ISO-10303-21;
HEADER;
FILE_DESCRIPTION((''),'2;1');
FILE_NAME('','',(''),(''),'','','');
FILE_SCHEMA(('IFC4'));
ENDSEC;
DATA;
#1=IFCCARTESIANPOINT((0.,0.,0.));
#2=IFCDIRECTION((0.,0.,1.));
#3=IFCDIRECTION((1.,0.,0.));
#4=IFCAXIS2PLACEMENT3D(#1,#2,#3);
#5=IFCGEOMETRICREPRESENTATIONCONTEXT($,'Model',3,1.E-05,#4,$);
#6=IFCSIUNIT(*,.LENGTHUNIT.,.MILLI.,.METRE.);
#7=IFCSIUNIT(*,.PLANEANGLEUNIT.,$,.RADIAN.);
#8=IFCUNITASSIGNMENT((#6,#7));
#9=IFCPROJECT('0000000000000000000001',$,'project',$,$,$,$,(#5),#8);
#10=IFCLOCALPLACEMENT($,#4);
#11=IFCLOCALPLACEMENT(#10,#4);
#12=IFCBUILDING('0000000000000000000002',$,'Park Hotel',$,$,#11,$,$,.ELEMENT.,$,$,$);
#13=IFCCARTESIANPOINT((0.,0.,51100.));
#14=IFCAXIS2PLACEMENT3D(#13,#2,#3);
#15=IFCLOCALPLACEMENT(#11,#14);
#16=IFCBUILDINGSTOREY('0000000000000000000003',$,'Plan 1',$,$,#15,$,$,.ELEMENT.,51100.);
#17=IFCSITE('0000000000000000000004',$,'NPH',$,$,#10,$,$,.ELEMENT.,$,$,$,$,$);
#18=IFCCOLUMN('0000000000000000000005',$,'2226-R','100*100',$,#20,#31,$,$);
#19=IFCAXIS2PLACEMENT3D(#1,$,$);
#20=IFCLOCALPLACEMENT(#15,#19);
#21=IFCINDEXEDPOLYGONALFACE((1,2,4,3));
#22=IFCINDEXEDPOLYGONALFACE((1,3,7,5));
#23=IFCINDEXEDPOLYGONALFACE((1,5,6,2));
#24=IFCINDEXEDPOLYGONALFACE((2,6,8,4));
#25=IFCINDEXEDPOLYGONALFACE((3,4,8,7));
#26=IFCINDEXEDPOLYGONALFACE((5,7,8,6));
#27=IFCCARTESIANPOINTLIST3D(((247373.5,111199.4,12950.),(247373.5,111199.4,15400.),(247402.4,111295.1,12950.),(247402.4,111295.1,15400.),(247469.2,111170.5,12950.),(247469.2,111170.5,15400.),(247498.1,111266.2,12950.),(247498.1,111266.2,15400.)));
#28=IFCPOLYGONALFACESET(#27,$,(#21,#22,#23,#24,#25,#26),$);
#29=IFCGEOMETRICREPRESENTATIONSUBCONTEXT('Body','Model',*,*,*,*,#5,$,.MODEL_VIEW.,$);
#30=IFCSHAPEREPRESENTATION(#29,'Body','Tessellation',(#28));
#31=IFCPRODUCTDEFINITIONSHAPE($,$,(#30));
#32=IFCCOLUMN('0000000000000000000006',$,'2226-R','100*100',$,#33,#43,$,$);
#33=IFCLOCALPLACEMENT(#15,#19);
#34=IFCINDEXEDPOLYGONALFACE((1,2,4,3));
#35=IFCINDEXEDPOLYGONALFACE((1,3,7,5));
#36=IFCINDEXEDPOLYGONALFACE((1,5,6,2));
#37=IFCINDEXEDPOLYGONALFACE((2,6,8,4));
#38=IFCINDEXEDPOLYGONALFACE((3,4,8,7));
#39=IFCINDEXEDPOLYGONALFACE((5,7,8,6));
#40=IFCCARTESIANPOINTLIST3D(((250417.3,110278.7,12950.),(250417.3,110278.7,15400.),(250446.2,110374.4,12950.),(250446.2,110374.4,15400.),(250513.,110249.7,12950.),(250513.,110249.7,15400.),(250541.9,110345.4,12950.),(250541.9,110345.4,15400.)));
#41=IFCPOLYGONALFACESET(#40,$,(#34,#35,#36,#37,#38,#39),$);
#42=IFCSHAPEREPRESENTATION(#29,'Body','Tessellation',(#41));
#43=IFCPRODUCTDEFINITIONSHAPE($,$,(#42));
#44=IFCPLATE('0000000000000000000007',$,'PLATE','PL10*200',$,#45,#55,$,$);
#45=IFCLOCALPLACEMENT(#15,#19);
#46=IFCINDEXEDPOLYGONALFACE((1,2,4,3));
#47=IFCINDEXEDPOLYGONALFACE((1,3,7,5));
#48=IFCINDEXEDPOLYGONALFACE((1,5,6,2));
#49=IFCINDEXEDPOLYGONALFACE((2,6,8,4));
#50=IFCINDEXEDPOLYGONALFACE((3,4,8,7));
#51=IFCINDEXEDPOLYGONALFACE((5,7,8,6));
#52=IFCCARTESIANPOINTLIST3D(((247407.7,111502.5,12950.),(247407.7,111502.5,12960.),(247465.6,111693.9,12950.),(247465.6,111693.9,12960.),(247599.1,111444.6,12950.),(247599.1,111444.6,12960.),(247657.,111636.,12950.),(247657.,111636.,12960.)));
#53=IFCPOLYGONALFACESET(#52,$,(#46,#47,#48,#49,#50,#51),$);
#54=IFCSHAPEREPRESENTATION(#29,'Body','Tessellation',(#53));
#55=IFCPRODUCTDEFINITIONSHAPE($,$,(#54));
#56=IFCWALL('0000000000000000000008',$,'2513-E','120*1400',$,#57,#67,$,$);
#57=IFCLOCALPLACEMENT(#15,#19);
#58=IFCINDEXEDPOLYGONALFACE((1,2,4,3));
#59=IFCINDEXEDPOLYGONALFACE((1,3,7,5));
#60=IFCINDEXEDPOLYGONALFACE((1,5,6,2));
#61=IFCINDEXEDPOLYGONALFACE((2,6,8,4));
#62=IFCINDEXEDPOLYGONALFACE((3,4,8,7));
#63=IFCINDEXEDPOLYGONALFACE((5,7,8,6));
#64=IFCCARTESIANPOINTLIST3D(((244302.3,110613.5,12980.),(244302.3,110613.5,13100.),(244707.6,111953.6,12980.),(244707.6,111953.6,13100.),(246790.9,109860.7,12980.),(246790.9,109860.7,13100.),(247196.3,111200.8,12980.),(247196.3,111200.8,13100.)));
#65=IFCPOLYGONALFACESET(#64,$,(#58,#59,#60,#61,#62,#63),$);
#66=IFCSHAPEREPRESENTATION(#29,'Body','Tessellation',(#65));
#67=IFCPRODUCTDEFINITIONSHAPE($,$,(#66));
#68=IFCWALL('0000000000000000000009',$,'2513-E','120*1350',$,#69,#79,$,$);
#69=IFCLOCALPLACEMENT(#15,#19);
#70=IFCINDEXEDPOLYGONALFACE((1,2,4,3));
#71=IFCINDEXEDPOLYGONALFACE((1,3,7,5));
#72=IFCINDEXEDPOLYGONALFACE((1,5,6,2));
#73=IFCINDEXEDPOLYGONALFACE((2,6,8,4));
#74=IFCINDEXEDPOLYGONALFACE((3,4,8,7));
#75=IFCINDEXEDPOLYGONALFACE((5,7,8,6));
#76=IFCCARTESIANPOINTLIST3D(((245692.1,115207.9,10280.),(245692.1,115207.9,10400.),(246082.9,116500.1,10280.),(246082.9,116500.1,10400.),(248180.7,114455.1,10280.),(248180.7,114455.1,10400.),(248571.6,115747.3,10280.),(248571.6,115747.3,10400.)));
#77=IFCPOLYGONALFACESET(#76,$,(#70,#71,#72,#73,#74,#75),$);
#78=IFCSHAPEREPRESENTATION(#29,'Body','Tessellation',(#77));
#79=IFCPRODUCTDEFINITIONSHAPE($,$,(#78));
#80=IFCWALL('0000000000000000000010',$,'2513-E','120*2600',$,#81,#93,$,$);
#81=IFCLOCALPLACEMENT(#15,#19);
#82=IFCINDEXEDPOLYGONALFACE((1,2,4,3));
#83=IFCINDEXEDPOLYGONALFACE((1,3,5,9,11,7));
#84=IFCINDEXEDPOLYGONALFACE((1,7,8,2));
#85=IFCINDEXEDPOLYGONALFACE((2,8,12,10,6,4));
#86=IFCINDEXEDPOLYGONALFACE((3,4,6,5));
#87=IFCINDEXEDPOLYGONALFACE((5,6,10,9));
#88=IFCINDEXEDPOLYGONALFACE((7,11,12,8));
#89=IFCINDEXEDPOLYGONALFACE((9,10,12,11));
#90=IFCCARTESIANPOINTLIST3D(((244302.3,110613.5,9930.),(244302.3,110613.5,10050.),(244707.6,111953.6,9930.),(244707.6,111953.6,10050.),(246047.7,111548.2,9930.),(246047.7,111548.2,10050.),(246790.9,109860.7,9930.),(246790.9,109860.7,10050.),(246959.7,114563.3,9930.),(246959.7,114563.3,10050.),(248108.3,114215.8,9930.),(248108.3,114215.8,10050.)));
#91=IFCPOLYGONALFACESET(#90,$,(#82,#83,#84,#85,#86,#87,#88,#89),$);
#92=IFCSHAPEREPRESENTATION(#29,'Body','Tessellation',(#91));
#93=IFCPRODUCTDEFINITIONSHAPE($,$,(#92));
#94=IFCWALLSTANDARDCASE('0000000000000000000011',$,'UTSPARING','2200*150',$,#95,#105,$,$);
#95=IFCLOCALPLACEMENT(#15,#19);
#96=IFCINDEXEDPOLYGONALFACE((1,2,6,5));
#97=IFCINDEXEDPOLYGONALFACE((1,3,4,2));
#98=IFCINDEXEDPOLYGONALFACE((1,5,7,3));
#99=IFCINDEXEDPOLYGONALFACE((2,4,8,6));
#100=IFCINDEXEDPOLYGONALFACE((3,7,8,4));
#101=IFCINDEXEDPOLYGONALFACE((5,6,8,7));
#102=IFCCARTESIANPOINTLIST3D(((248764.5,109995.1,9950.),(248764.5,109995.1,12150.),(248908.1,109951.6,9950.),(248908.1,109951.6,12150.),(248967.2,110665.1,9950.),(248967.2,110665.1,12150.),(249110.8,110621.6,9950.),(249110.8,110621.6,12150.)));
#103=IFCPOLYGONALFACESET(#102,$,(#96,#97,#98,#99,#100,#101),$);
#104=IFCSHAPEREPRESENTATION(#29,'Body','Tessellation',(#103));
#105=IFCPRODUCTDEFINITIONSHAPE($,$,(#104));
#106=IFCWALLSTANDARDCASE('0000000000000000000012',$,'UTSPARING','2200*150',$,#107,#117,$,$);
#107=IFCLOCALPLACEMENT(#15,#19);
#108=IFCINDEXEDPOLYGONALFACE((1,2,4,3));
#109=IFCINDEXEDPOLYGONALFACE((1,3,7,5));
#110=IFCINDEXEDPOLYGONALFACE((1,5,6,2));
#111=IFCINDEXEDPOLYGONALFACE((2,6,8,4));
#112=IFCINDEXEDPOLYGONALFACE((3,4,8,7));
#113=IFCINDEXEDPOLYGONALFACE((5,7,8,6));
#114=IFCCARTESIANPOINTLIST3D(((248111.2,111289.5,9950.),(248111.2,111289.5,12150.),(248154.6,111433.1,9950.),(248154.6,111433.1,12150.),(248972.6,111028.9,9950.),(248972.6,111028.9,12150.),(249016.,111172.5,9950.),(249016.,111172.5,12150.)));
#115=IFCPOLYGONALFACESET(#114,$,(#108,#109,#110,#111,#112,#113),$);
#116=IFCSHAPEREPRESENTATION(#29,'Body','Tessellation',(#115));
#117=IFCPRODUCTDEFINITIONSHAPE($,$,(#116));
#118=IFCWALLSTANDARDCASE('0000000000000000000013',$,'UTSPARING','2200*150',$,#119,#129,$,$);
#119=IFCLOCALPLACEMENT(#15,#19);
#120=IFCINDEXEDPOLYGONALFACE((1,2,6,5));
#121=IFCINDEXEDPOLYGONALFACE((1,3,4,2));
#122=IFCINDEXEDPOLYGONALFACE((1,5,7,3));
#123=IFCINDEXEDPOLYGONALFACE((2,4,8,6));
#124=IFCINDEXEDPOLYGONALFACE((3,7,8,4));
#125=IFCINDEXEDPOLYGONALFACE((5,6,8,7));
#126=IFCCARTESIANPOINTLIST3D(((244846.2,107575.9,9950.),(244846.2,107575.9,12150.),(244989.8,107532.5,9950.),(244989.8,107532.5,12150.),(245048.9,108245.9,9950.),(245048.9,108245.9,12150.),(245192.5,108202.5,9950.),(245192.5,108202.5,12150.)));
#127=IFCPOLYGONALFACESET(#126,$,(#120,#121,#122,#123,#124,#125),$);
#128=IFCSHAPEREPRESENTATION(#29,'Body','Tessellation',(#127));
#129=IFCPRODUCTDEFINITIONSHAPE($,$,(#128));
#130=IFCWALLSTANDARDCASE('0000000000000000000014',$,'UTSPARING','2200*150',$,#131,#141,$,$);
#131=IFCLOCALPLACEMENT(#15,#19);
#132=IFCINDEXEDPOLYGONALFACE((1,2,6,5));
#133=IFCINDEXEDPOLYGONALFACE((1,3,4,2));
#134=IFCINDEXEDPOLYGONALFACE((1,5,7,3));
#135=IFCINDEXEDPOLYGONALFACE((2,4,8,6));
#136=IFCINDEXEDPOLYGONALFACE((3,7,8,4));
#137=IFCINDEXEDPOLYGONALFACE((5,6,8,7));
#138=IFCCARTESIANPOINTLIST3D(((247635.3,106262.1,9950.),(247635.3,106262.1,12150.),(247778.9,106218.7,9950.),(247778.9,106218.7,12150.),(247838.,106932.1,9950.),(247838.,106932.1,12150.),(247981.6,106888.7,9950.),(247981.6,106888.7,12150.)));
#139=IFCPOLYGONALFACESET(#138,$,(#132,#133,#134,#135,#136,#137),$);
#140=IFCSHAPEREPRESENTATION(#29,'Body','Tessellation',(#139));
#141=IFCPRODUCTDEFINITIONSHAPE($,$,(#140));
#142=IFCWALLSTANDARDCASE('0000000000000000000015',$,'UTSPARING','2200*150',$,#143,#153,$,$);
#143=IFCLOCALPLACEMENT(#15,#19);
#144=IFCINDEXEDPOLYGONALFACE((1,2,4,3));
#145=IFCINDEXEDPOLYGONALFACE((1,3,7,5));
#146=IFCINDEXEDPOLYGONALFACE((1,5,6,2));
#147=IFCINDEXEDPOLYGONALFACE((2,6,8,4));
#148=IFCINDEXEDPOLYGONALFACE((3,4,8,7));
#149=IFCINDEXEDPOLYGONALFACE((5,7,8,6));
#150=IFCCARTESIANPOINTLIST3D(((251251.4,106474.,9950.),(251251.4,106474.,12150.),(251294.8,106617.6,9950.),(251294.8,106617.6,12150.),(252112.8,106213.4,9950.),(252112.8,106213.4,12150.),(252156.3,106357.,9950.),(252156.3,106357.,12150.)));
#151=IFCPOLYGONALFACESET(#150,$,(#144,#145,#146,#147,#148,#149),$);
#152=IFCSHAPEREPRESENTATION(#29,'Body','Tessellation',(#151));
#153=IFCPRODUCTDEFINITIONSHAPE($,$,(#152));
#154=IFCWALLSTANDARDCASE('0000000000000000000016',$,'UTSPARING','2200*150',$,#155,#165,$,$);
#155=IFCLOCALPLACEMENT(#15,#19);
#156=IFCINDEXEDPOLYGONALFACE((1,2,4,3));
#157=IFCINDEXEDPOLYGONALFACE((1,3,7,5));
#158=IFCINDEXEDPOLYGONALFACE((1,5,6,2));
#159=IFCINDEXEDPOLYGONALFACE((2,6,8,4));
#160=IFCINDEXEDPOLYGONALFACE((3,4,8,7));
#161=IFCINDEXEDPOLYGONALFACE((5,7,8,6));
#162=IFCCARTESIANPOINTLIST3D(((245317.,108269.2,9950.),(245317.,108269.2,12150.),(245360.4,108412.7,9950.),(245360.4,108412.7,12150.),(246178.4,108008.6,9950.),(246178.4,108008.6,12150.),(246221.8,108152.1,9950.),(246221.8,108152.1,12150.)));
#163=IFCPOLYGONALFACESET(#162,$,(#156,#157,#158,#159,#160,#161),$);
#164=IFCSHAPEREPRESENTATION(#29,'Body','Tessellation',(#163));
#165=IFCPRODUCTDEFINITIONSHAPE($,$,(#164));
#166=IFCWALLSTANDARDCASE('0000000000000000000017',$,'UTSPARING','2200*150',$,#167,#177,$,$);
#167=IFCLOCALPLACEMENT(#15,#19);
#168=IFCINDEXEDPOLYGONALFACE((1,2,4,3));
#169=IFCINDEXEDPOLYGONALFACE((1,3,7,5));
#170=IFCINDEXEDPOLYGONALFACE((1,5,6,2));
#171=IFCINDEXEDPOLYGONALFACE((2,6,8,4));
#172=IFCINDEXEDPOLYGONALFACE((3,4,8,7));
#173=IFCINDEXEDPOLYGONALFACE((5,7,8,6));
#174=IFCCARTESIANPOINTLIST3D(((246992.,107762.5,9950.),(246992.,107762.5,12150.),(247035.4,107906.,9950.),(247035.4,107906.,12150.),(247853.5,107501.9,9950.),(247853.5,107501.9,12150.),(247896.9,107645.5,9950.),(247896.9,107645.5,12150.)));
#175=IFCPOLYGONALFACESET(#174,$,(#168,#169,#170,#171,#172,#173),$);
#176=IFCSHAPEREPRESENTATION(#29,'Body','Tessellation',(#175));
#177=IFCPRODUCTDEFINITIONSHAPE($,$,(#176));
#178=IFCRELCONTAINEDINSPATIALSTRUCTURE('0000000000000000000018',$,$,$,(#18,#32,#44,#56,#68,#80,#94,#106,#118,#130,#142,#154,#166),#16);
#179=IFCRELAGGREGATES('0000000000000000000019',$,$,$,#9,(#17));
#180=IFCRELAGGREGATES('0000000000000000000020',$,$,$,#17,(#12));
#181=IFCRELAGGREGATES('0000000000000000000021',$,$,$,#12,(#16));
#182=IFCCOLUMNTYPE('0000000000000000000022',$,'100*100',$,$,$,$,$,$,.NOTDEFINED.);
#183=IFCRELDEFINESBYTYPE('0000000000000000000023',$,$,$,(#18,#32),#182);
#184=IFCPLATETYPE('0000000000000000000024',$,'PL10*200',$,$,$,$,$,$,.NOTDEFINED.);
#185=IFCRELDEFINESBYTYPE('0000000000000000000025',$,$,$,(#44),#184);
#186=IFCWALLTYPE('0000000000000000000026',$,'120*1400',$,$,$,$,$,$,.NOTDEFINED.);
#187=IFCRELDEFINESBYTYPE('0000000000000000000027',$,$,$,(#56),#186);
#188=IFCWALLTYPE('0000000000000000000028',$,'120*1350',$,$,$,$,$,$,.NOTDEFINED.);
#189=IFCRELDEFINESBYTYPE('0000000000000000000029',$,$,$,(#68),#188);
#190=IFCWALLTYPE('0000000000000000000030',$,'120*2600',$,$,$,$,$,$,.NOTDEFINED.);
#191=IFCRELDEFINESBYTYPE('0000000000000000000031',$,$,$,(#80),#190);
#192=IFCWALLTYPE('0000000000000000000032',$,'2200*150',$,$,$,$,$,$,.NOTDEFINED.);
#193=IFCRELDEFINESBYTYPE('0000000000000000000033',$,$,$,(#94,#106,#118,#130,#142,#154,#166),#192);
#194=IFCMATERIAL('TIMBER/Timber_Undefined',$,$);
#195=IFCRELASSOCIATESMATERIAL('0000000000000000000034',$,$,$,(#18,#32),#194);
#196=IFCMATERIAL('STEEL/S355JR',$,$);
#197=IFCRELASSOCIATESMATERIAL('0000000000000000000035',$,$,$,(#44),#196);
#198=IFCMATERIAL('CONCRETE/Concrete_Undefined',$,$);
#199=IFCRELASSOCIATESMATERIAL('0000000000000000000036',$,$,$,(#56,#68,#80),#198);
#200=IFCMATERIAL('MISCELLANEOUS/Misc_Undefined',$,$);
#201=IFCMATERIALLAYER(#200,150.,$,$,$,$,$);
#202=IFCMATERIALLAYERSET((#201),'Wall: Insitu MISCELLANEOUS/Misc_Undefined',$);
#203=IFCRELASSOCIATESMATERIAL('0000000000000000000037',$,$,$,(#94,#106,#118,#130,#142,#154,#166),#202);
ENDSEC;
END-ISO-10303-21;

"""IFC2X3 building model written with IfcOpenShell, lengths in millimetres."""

from ifc_helpers import new_model, si_unit, frame, frame_2d, origin_with_axes, origin_2d_with_axis, place, context, subcontext, project, spatial, polyline, rectangle, outline, extrude, material, layer, layer_set, layer_usage, type_object, element, save


model = new_model("IFC2X3")

# Units and contexts
model_context = context("Model", 3, precision=1e-05, world=origin_with_axes())
body_context = subcontext(model_context, "Body", "Model", "MODEL_VIEW")
ifc_project = project(units=[si_unit("LENGTHUNIT", "METRE", prefix="MILLI"), si_unit("PLANEANGLEUNIT", "RADIAN")], contexts=[model_context])

# Site, building, storey
site_placement = place(None, origin_with_axes())
site = spatial("IfcSite", under=ifc_project, at=site_placement, Name="NPH", CompositionType="ELEMENT")
building_placement = place(site_placement, origin_with_axes())
building = spatial("IfcBuilding", under=site, at=building_placement, Name="Park Hotel", CompositionType="ELEMENT")
storey_placement = place(building_placement, frame((0.0, 0.0, 51100.0), z_axis=(0.0, 0.0, 1.0), x_axis=(1.0, 0.0, 0.0)))
storey = spatial("IfcBuildingStorey", under=building, at=storey_placement, Name="Plan 1", CompositionType="ELEMENT", Elevation=51100.0)

# Columns
ifc_material_1 = material(Name="TIMBER/Timber_Undefined")
column_type = type_object("IfcColumnType", Name="100*100", PredefinedType="NOTDEFINED")
for number, where, z_axis, x_axis, name in (
    (1, (247435.8, 111232.8, 15400.0), (0.0, 0.0, -1.0), (0.289538, 0.957167, 0.0), "2226-R"),
    (2, (250479.6, 110312.1, 15400.0), (0.0, 0.0, -1.0), (0.289538, 0.957167, 0.0), "2226-R"),
):
    element("IfcColumn", number, at=place(storey_placement, frame(where, z_axis=z_axis, x_axis=x_axis)), inside=storey, type_object=column_type, material=ifc_material_1, Name=name, Description="100*100", context=body_context, shape_type="SweptSolid", body=[
        extrude(rectangle(XDim=100.0, YDim=100.0, at=origin_2d_with_axis()), frame((0.0, 0.0, 2450.0), z_axis=(0.0, 0.0, -1.0), x_axis=(0.0, 1.0, 0.0)), (0.0, 0.0, 1.0), 2450.0),
    ])

# Plate
ifc_material_2 = material(Name="STEEL/S355JR")
plate_type = type_object("IfcPlateType", Name="PL10*200", PredefinedType="NOTDEFINED")
plate_placement = place(storey_placement, frame((247628.1, 111540.3, 12955.0), z_axis=(0.0, 0.0, 1.0), x_axis=(-0.957167, 0.289538, 0.0)))
element("IfcPlate", 3, at=plate_placement, inside=storey, type_object=plate_type, material=ifc_material_2, Name="PLATE", Description="PL10*200", context=body_context, shape_type="SweptSolid", body=[
    extrude(outline(polyline([(200.0, 100.0), (200.0, -100.0), (0.0, -100.0), (0.0, 100.0), (200.0, 100.0)])), frame((0.0, 0.0, -5.0), z_axis=(0.0, 0.0, 1.0), x_axis=(1.0, 0.0, 0.0)), (0.0, 0.0, 1.0), 10.0),
])

# Walls
ifc_material_3 = material(Name="CONCRETE/Concrete_Undefined")
wall_type_1 = type_object("IfcWallType", Name="120*1400", PredefinedType="NOTDEFINED")
wall_1_placement = place(storey_placement, frame((246790.9, 109860.7, 13040.0), z_axis=(0.0, 0.0, 1.0), x_axis=(0.289538, 0.957167, 0.0)))
element("IfcWall", 4, at=wall_1_placement, inside=storey, type_object=wall_type_1, material=ifc_material_3, Name="2513-E", Description="120*1400", context=body_context, shape_type="SweptSolid", body=[
    extrude(outline(polyline([(0.0, 0.0), (1400.0, 0.0), (1400.0, 2600.0), (0.0, 2600.0), (0.0, 0.0)])), frame((0.0, 0.0, -60.0), z_axis=(0.0, 0.0, 1.0), x_axis=(1.0, 0.0, 0.0)), (0.0, 0.0, 1.0), 120.0),
])
wall_type_2 = type_object("IfcWallType", Name="120*1350", PredefinedType="NOTDEFINED")
wall_2_placement = place(storey_placement, frame((248180.7, 114455.1, 10340.0), z_axis=(0.0, 0.0, 1.0), x_axis=(0.289538, 0.957167, 0.0)))
element("IfcWall", 5, at=wall_2_placement, inside=storey, type_object=wall_type_2, material=ifc_material_3, Name="2513-E", Description="120*1350", context=body_context, shape_type="SweptSolid", body=[
    extrude(outline(polyline([(0.0, 0.0), (1350.0, 0.0), (1350.0, 2600.0), (0.0, 2600.0), (0.0, 0.0)])), frame((0.0, 0.0, -60.0), z_axis=(0.0, 0.0, 1.0), x_axis=(1.0, 0.0, 0.0)), (0.0, 0.0, 1.0), 120.0),
])
wall_type_3 = type_object("IfcWallType", Name="120*2600", PredefinedType="NOTDEFINED")
wall_3_placement = place(storey_placement, frame((246790.9, 109860.7, 9990.0), z_axis=(0.0, 0.0, 1.0), x_axis=(0.289538, 0.957167, 0.0)))
element("IfcWall", 6, at=wall_3_placement, inside=storey, type_object=wall_type_3, material=ifc_material_3, Name="2513-E", Description="120*2600", context=body_context, shape_type="SweptSolid", body=[
    extrude(outline(polyline([(0.0, 0.0), (4550.0, 0.0), (4550.0, 1200.0), (1400.0, 1200.0), (1400.0, 2600.0), (0.0, 2600.0), (0.0, 0.0)])), frame((0.0, 0.0, -60.0), z_axis=(0.0, 0.0, 1.0), x_axis=(1.0, 0.0, 0.0)), (0.0, 0.0, 1.0), 120.0),
])
ifc_material_4 = material(Name="MISCELLANEOUS/Misc_Undefined")
ifc_layer_1 = layer(ifc_material_4, 150.0)
ifc_layer_set_1 = layer_set([ifc_layer_1], Name="Wall: Insitu MISCELLANEOUS/Misc_Undefined")
ifc_layer_usage_1 = layer_usage(ifc_layer_set_1, "AXIS2", "POSITIVE", -75.0)
wall_type_4 = type_object("IfcWallType", Name="2200*150", PredefinedType="NOTDEFINED")
wall_4_placement = place(storey_placement, frame((249039.0, 110643.4, 9950.0), z_axis=(0.0, 0.0, 1.0), x_axis=(-0.289534, -0.957168, 0.0)))
element("IfcWallStandardCase", 7, at=wall_4_placement, inside=storey, type_object=wall_type_4, material=ifc_layer_usage_1, Name="UTSPARING", Description="2200*150", context=body_context, shape_type="SweptSolid", body=[
    extrude(rectangle(XDim=700.0, YDim=150.0, at=frame_2d((0.0, 350.0), x_axis=(0.0, -1.0))), frame((0.0, 0.0, 0.0), z_axis=(0.0, 0.0, 1.0), x_axis=(0.0, -1.0, 0.0)), (0.0, 0.0, 1.0), 2200.0),
])
ifc_layer_usage_2 = layer_usage(ifc_layer_set_1, "AXIS2", "POSITIVE", -75.0)
wall_5_placement = place(storey_placement, frame((248132.9, 111361.3, 9950.0), z_axis=(0.0, 0.0, 1.0), x_axis=(0.957166, -0.289541, 0.0)))
element("IfcWallStandardCase", 8, at=wall_5_placement, inside=storey, type_object=wall_type_4, material=ifc_layer_usage_2, Name="UTSPARING", Description="2200*150", context=body_context, shape_type="SweptSolid", body=[
    extrude(rectangle(XDim=900.0, YDim=150.0, at=frame_2d((0.0, 450.0), x_axis=(0.0, -1.0))), frame((0.0, 0.0, 0.0), z_axis=(0.0, 0.0, 1.0), x_axis=(0.0, -1.0, 0.0)), (0.0, 0.0, 1.0), 2200.0),
])
ifc_layer_usage_3 = layer_usage(ifc_layer_set_1, "AXIS2", "POSITIVE", -75.0)
wall_6_placement = place(storey_placement, frame((244918.0, 107554.2, 9950.0), z_axis=(0.0, 0.0, 1.0), x_axis=(0.289542, 0.957165, 0.0)))
element("IfcWallStandardCase", 9, at=wall_6_placement, inside=storey, type_object=wall_type_4, material=ifc_layer_usage_3, Name="UTSPARING", Description="2200*150", context=body_context, shape_type="SweptSolid", body=[
    extrude(rectangle(XDim=700.0, YDim=150.0, at=frame_2d((0.0, 350.0), x_axis=(0.0, -1.0))), frame((0.0, 0.0, 0.0), z_axis=(0.0, 0.0, 1.0), x_axis=(0.0, -1.0, 0.0)), (0.0, 0.0, 1.0), 2200.0),
])
ifc_layer_usage_4 = layer_usage(ifc_layer_set_1, "AXIS2", "POSITIVE", -75.0)
wall_7_placement = place(storey_placement, frame((247707.1, 106240.4, 9950.0), z_axis=(0.0, 0.0, 1.0), x_axis=(0.289542, 0.957165, 0.0)))
element("IfcWallStandardCase", 10, at=wall_7_placement, inside=storey, type_object=wall_type_4, material=ifc_layer_usage_4, Name="UTSPARING", Description="2200*150", context=body_context, shape_type="SweptSolid", body=[
    extrude(rectangle(XDim=700.0, YDim=150.0, at=frame_2d((0.0, 350.0), x_axis=(0.0, -1.0))), frame((0.0, 0.0, 0.0), z_axis=(0.0, 0.0, 1.0), x_axis=(0.0, -1.0, 0.0)), (0.0, 0.0, 1.0), 2200.0),
])
ifc_layer_usage_5 = layer_usage(ifc_layer_set_1, "AXIS2", "POSITIVE", -75.0)
wall_8_placement = place(storey_placement, frame((251273.1, 106545.8, 9950.0), z_axis=(0.0, 0.0, 1.0), x_axis=(0.957166, -0.289541, 0.0)))
element("IfcWallStandardCase", 11, at=wall_8_placement, inside=storey, type_object=wall_type_4, material=ifc_layer_usage_5, Name="UTSPARING", Description="2200*150", context=body_context, shape_type="SweptSolid", body=[
    extrude(rectangle(XDim=900.0, YDim=150.0, at=frame_2d((0.0, 450.0), x_axis=(0.0, -1.0))), frame((0.0, 0.0, 0.0), z_axis=(0.0, 0.0, 1.0), x_axis=(0.0, -1.0, 0.0)), (0.0, 0.0, 1.0), 2200.0),
])
ifc_layer_usage_6 = layer_usage(ifc_layer_set_1, "AXIS2", "POSITIVE", -75.0)
wall_9_placement = place(storey_placement, frame((245338.7, 108340.9, 9950.0), z_axis=(0.0, 0.0, 1.0), x_axis=(0.957166, -0.289541, 0.0)))
element("IfcWallStandardCase", 12, at=wall_9_placement, inside=storey, type_object=wall_type_4, material=ifc_layer_usage_6, Name="UTSPARING", Description="2200*150", context=body_context, shape_type="SweptSolid", body=[
    extrude(rectangle(XDim=900.0, YDim=150.0, at=frame_2d((0.0, 450.0), x_axis=(0.0, -1.0))), frame((0.0, 0.0, 0.0), z_axis=(0.0, 0.0, 1.0), x_axis=(0.0, -1.0, 0.0)), (0.0, 0.0, 1.0), 2200.0),
])
ifc_layer_usage_7 = layer_usage(ifc_layer_set_1, "AXIS2", "POSITIVE", -75.0)
wall_10_placement = place(storey_placement, frame((247013.7, 107834.3, 9950.0), z_axis=(0.0, 0.0, 1.0), x_axis=(0.957166, -0.289541, 0.0)))
element("IfcWallStandardCase", 13, at=wall_10_placement, inside=storey, type_object=wall_type_4, material=ifc_layer_usage_7, Name="UTSPARING", Description="2200*150", context=body_context, shape_type="SweptSolid", body=[
    extrude(rectangle(XDim=900.0, YDim=150.0, at=frame_2d((0.0, 450.0), x_axis=(0.0, -1.0))), frame((0.0, 0.0, 0.0), z_axis=(0.0, 0.0, 1.0), x_axis=(0.0, -1.0, 0.0)), (0.0, 0.0, 1.0), 2200.0),
])

save(model, "model.ifc")
